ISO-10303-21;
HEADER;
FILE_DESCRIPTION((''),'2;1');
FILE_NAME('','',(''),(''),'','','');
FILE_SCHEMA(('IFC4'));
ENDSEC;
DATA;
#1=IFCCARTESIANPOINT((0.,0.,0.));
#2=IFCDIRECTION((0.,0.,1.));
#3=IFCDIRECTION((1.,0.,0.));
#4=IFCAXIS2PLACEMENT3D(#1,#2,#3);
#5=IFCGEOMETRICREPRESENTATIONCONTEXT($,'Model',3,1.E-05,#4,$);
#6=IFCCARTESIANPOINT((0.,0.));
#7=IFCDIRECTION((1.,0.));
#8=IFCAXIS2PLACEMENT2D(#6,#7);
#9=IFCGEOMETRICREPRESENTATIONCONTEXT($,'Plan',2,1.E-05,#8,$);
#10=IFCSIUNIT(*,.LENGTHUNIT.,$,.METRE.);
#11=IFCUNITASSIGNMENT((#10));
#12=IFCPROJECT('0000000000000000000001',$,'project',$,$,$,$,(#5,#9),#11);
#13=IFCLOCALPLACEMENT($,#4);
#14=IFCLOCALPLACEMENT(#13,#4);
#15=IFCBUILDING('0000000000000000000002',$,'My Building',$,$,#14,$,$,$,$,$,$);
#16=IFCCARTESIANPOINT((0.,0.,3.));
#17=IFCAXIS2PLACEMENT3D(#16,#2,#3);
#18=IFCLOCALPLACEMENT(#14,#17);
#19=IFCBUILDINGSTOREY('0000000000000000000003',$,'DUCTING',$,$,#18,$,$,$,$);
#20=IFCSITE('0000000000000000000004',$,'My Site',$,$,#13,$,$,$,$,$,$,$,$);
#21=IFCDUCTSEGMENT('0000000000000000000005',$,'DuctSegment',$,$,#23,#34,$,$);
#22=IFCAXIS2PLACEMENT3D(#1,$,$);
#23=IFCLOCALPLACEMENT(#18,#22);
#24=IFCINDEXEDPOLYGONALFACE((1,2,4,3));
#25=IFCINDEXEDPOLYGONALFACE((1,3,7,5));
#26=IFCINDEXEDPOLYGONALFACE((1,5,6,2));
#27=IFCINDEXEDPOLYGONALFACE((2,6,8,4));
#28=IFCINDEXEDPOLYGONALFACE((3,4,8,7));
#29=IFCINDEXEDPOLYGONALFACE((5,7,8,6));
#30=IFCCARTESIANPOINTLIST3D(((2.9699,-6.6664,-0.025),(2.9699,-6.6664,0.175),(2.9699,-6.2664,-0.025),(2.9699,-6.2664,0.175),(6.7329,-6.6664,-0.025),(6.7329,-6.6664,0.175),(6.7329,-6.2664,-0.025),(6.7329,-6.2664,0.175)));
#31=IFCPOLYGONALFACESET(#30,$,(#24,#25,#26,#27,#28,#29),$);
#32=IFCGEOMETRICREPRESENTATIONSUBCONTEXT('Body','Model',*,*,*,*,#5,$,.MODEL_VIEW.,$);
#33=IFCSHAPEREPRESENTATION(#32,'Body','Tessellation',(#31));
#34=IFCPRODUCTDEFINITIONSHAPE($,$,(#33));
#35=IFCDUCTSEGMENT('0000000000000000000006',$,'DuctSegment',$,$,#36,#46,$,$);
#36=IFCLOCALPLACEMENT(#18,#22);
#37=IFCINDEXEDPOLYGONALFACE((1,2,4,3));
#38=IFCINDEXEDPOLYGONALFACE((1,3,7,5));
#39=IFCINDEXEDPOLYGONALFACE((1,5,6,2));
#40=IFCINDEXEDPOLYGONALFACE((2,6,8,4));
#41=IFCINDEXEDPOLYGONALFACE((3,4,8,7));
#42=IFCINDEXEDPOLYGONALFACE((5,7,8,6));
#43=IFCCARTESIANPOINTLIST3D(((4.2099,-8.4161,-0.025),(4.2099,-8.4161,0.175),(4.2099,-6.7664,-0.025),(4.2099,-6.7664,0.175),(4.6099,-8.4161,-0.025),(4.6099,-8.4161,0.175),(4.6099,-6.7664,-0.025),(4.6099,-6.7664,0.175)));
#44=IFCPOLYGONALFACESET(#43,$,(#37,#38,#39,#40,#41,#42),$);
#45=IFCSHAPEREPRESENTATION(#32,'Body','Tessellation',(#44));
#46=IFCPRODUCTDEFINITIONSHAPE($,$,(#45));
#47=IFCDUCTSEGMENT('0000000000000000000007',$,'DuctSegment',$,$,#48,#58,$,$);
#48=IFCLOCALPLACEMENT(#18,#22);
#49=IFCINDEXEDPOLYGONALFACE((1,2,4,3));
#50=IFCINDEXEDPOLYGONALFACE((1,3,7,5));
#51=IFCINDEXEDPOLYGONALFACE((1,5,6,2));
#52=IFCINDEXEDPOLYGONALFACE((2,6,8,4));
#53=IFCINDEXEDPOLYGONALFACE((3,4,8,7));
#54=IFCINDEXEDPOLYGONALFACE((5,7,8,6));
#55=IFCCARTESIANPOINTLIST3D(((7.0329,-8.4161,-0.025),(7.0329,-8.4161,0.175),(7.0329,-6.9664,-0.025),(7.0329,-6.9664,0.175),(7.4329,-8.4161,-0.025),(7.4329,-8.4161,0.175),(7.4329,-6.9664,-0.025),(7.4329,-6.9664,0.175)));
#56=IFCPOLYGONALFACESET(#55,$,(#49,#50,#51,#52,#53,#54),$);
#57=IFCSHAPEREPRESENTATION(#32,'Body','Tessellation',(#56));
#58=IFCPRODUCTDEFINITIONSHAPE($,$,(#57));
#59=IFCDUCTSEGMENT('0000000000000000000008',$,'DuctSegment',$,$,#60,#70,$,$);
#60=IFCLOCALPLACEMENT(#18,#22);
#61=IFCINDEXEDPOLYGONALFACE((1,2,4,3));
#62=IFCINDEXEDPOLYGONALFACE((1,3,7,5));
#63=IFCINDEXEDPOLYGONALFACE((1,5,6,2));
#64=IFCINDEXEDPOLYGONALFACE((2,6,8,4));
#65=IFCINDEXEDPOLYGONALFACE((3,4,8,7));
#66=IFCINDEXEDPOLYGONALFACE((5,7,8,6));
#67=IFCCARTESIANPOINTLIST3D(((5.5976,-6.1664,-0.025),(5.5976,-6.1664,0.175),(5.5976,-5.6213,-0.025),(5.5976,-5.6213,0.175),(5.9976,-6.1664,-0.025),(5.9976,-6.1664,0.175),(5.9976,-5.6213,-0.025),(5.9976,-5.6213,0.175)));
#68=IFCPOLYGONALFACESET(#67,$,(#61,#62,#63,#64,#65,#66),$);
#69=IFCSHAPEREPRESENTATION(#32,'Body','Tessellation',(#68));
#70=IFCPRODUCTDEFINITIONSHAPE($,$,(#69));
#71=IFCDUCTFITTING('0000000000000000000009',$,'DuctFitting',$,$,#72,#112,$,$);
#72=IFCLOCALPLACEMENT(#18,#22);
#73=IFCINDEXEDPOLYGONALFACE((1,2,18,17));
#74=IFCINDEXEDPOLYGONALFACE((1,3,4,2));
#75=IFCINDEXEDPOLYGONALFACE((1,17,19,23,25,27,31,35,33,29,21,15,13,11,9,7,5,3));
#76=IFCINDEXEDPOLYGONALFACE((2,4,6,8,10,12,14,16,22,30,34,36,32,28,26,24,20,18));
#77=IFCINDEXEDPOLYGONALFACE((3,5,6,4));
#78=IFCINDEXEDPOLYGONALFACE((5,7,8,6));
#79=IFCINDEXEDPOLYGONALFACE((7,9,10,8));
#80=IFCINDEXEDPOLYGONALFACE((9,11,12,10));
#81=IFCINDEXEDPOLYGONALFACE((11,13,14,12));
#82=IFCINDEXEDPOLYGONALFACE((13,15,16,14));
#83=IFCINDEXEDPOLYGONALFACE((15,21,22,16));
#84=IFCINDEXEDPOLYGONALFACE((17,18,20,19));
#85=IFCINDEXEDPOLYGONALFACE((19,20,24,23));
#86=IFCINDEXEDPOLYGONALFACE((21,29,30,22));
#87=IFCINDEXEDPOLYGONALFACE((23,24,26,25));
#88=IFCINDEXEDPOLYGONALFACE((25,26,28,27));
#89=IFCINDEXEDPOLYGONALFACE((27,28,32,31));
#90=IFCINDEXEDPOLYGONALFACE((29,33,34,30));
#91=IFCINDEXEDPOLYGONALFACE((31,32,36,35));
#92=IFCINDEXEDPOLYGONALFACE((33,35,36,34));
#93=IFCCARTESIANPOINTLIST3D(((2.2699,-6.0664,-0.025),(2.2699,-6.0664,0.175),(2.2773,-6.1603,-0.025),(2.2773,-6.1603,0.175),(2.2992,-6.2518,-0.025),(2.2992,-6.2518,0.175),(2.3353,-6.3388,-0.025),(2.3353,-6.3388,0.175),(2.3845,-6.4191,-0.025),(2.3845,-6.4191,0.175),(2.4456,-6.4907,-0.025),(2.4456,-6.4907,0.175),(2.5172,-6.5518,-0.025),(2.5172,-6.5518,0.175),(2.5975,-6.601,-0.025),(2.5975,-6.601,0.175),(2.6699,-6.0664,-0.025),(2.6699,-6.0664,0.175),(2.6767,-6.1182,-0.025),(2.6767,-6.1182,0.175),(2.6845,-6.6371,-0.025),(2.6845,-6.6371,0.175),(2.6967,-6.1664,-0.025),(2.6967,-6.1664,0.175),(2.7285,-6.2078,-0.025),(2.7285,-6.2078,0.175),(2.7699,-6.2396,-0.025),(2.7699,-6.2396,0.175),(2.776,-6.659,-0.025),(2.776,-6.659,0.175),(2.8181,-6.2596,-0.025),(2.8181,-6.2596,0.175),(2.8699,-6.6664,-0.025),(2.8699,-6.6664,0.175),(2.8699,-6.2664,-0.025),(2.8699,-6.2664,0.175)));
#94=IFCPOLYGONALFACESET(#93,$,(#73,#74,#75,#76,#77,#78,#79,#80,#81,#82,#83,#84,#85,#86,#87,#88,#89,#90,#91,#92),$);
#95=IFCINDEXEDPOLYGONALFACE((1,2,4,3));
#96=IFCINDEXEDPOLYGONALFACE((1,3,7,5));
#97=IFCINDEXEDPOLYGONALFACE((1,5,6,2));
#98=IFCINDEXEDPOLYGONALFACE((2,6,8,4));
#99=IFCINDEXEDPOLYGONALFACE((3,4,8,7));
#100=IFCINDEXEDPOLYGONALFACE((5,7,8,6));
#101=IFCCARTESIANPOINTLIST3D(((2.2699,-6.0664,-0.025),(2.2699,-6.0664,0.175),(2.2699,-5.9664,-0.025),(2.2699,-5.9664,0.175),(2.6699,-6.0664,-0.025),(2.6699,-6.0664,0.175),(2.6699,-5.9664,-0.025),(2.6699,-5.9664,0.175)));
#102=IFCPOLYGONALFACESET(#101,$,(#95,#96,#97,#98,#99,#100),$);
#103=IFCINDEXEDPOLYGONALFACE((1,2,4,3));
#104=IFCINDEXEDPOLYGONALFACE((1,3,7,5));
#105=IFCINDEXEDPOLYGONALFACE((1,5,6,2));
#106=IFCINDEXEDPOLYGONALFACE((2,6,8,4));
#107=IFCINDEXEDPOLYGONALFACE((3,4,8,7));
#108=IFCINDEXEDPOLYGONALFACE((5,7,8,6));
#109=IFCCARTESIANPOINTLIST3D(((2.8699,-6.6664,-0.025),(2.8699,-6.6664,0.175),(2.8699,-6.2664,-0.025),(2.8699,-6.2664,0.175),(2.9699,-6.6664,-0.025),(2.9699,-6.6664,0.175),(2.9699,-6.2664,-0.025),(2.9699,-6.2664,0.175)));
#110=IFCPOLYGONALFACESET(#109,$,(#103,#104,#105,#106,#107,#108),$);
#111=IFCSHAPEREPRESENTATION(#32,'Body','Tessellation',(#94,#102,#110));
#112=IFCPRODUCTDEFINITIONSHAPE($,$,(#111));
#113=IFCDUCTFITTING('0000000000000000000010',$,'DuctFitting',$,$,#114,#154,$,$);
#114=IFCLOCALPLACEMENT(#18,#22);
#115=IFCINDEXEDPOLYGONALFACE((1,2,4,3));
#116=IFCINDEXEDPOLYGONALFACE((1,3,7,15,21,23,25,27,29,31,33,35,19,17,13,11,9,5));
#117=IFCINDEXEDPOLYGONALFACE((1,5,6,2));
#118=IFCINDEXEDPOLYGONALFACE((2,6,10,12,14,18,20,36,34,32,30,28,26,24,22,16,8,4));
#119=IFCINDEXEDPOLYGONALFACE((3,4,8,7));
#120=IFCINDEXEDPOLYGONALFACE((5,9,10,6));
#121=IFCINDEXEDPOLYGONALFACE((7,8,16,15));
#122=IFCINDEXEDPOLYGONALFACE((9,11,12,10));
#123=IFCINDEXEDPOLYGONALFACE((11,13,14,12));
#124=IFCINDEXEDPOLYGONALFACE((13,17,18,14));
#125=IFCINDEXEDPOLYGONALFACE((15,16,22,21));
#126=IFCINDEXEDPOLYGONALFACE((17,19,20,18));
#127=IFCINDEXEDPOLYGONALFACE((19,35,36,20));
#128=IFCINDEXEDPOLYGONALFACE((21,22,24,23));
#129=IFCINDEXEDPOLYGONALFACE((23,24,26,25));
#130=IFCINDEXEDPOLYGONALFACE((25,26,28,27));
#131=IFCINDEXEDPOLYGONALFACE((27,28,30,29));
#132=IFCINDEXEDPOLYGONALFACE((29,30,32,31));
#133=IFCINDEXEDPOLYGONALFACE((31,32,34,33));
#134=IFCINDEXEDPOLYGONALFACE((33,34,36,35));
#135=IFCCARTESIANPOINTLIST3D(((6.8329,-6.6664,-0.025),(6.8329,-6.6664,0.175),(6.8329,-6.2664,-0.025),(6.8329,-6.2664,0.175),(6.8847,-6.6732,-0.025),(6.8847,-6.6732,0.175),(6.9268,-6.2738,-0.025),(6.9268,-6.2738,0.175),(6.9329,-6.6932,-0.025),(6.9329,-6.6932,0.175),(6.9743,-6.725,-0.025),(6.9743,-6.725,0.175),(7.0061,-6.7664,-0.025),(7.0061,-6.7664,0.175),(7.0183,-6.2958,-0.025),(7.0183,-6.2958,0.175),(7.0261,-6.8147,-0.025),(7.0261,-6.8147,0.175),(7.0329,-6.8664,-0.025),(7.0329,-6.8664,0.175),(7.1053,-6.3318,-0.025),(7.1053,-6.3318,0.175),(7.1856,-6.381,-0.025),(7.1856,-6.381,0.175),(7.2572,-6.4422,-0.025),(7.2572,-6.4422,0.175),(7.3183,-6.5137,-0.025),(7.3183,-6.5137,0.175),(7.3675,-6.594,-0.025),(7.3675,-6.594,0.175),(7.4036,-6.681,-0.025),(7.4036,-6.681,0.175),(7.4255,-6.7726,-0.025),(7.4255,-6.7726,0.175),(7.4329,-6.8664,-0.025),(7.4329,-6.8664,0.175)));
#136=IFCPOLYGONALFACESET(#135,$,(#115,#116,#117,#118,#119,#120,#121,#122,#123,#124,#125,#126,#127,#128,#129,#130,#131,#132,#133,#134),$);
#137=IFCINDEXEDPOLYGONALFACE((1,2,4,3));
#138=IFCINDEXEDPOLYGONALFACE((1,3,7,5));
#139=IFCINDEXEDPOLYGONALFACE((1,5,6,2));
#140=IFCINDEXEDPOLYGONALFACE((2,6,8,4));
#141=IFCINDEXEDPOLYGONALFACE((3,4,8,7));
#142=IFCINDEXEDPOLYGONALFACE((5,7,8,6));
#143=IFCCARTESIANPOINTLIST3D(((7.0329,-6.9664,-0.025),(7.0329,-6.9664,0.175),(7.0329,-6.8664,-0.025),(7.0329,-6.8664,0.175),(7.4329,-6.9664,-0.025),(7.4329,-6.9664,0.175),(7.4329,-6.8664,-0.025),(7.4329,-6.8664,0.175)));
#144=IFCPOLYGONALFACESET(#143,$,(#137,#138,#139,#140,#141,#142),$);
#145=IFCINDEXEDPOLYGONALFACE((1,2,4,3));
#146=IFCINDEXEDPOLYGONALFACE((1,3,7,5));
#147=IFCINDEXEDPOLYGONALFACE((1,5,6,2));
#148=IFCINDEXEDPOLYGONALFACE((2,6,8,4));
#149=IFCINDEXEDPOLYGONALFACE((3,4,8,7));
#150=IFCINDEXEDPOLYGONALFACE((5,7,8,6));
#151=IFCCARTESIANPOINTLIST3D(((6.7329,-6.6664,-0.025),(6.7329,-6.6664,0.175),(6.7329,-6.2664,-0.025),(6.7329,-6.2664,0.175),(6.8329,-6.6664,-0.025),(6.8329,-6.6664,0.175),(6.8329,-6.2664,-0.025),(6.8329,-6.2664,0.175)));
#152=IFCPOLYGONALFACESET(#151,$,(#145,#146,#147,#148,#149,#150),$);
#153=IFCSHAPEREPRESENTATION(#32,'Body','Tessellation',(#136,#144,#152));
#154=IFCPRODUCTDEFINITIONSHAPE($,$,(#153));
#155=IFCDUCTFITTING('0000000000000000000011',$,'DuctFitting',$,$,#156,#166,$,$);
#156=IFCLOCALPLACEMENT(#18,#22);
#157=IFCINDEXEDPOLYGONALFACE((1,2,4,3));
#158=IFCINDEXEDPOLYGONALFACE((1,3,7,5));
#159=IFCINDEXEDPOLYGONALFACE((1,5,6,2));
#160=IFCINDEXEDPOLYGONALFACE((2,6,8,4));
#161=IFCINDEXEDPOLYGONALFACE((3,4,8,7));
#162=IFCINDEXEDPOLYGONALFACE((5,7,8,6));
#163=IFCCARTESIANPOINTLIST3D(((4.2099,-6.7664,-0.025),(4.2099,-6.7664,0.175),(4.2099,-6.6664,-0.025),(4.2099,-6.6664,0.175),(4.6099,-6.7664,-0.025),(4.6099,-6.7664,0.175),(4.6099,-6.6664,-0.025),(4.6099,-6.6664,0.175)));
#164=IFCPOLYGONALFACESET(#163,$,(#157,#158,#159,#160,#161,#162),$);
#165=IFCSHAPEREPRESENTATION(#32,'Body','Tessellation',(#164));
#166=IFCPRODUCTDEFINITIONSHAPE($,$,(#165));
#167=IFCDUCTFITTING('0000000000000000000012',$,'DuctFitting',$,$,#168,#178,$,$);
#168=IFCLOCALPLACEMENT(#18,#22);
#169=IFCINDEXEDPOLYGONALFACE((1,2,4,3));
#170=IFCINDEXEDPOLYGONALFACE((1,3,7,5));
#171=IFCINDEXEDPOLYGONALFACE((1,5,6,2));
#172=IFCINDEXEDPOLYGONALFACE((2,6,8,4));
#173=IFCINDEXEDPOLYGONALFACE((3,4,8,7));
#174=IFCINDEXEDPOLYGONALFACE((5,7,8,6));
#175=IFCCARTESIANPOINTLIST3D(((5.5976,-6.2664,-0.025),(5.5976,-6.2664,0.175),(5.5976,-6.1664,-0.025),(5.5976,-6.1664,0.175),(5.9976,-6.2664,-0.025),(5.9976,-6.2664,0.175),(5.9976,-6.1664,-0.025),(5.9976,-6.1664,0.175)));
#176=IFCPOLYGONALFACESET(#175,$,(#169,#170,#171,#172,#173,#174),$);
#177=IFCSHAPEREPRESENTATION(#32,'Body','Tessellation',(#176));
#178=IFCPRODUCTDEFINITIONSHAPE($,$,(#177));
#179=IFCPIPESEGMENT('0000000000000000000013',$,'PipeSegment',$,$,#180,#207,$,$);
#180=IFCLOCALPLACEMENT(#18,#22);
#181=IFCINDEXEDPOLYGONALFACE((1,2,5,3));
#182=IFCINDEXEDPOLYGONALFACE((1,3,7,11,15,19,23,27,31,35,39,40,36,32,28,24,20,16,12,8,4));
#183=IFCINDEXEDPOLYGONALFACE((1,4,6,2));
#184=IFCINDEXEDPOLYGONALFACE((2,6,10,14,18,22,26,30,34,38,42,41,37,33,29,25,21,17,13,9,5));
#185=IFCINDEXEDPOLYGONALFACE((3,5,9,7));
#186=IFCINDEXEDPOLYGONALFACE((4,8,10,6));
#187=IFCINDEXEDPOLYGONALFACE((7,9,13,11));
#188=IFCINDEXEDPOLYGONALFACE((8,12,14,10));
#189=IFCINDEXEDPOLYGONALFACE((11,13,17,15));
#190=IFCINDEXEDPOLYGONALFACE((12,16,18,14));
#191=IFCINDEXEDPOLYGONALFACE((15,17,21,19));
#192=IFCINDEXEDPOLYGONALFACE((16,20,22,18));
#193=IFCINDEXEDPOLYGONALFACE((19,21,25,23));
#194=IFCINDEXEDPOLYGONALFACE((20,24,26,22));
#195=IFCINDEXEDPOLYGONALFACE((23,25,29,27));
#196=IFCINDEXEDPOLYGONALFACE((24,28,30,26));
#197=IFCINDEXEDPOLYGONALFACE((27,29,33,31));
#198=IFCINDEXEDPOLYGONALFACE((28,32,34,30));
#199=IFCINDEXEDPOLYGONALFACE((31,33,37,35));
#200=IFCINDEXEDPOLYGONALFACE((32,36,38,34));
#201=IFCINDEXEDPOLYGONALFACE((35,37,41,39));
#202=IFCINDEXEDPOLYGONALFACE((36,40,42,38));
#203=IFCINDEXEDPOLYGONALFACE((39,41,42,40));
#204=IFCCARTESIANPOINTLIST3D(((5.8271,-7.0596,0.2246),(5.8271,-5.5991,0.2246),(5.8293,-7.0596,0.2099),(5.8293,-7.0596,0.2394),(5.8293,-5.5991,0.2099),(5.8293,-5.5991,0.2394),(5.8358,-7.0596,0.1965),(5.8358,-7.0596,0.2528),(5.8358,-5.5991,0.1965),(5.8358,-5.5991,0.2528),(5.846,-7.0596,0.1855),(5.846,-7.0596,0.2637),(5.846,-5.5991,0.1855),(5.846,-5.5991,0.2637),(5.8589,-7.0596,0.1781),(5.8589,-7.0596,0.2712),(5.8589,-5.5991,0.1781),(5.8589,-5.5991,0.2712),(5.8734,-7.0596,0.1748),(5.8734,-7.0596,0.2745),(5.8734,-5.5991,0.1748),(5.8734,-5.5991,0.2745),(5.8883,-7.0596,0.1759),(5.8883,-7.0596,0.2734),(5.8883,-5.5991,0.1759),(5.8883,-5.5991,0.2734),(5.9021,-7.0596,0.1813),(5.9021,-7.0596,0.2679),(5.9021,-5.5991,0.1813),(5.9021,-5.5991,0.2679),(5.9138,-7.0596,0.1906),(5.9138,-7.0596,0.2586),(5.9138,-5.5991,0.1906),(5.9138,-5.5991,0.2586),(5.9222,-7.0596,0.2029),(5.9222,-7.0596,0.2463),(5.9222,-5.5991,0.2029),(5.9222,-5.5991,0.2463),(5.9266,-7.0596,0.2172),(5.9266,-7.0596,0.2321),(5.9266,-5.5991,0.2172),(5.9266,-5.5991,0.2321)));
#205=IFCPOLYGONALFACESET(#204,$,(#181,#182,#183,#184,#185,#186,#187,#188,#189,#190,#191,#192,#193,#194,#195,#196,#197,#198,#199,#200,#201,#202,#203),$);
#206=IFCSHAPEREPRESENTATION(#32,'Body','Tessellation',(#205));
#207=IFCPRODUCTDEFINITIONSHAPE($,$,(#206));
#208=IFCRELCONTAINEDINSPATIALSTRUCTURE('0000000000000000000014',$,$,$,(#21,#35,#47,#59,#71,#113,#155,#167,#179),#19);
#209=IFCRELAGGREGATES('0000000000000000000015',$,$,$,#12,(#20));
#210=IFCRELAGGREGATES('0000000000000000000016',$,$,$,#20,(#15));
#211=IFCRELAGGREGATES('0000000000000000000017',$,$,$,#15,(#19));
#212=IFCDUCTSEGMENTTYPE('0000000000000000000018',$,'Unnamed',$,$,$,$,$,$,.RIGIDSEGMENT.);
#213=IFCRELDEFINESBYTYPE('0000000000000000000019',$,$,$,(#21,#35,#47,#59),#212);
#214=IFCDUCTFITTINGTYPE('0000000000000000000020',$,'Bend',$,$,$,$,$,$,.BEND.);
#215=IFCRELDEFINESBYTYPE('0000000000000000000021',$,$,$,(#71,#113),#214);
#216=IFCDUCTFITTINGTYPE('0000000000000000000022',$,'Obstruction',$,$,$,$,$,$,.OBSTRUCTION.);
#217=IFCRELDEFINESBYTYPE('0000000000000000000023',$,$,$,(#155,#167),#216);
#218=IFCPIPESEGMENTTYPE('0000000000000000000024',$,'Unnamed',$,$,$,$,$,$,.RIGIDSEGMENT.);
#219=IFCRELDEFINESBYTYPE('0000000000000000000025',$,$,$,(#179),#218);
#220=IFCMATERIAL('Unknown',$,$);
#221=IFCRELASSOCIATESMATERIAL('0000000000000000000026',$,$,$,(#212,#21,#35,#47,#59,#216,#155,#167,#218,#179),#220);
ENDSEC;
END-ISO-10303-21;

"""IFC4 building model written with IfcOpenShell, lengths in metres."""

from ifc_helpers import new_model, si_unit, frame, origin_with_axes, origin_2d_with_axis, place, context, subcontext, project, spatial, line, arc, indexed_curve, rectangle, circle, outline, extrude, source, transform, mapped, material, material_profile, profile_set, profile_usage, type_object, type_shapes, element, save


model = new_model("IFC4")

# Units and contexts
model_context = context("Model", 3, precision=1e-05, world=origin_with_axes())
plan_context = context("Plan", 2, precision=1e-05, world=origin_2d_with_axis())
body_context = subcontext(model_context, "Body", "Model", "MODEL_VIEW")
ifc_project = project(units=[si_unit("LENGTHUNIT", "METRE")], contexts=[model_context, plan_context])

# Site, building, storey
site_placement = place(None, origin_with_axes())
site = spatial("IfcSite", under=ifc_project, at=site_placement, Name="My Site")
building_placement = place(site_placement, origin_with_axes())
building = spatial("IfcBuilding", under=site, at=building_placement, Name="My Building")
storey_placement = place(building_placement, frame((0.0, 0.0, 3.0), z_axis=(0.0, 0.0, 1.0), x_axis=(1.0, 0.0, 0.0)))
storey = spatial("IfcBuildingStorey", under=building, at=storey_placement, Name="DUCTING")

# Duct segments
ifc_material = material(Name="Unknown")
ifc_material_profile_1 = material_profile(ifc_material, rectangle(XDim=0.4, YDim=0.2))
ifc_profile_set_1 = profile_set([ifc_material_profile_1])
ifc_profile_usage_1 = profile_usage(ifc_profile_set_1, cardinal=5)
duct_segment_type = type_object("IfcDuctSegmentType", Name="Unnamed", PredefinedType="RIGIDSEGMENT", material=ifc_profile_set_1)
duct_segment_1_placement = place(storey_placement, frame((2.9699, -6.4664, 0.075), z_axis=(1.0, 0.0, 0.0), x_axis=(0.0, 1.0, 0.0)))
element("IfcDuctSegment", 1, at=duct_segment_1_placement, inside=storey, type_object=duct_segment_type, material=ifc_profile_usage_1, Name="DuctSegment", context=body_context, shape_type="SweptSolid", body=[
    extrude(rectangle(XDim=0.4, YDim=0.2), origin_with_axes(), (0.0, 0.0, 1.0), 3.763),
])
ifc_profile_usage_2 = profile_usage(ifc_profile_set_1, cardinal=5)
duct_segment_2_placement = place(storey_placement, frame((4.4099, -6.7664, 0.075), z_axis=(0.0, -1.0, 0.0), x_axis=(1.0, 0.0, 0.0)))
element("IfcDuctSegment", 2, at=duct_segment_2_placement, inside=storey, type_object=duct_segment_type, material=ifc_profile_usage_2, Name="DuctSegment", context=body_context, shape_type="SweptSolid", body=[
    extrude(rectangle(XDim=0.4, YDim=0.2), origin_with_axes(), (0.0, 0.0, 1.0), 1.6497),
])
ifc_profile_usage_3 = profile_usage(ifc_profile_set_1, cardinal=5)
duct_segment_3_placement = place(storey_placement, frame((7.2329, -6.9664, 0.075), z_axis=(0.0, -1.0, 0.0), x_axis=(1.0, 0.0, 0.0)))
element("IfcDuctSegment", 3, at=duct_segment_3_placement, inside=storey, type_object=duct_segment_type, material=ifc_profile_usage_3, Name="DuctSegment", context=body_context, shape_type="SweptSolid", body=[
    extrude(rectangle(XDim=0.4, YDim=0.2), origin_with_axes(), (0.0, 0.0, 1.0), 1.4497),
])
ifc_profile_usage_4 = profile_usage(ifc_profile_set_1, cardinal=5)
duct_segment_4_placement = place(storey_placement, frame((5.7976, -6.1664, 0.075), z_axis=(0.0, 1.0, 0.0), x_axis=(-1.0, 0.0, 0.0)))
element("IfcDuctSegment", 4, at=duct_segment_4_placement, inside=storey, type_object=duct_segment_type, material=ifc_profile_usage_4, Name="DuctSegment", context=body_context, shape_type="SweptSolid", body=[
    extrude(rectangle(XDim=0.4, YDim=0.2), origin_with_axes(), (0.0, 0.0, 1.0), 0.5451),
])

# Duct fittings
duct_fitting_type_1 = type_object("IfcDuctFittingType", Name="Bend", PredefinedType="BEND")
shared_shape_1 = source(origin_with_axes(), body_context, "Body", "SweptSolid", [
    extrude(outline(indexed_curve([(0.2, 0.0), (0.2586, 0.1414), (0.4, 0.2), (0.4, 0.6), (-0.0243, 0.4243), (-0.2, 0.0)], segments=[arc(1, 2, 3), line(3, 4), arc(4, 5, 6), line(6, 1)])), frame((0.0, -0.1, 0.1), z_axis=(0.0, -1.0, 0.0), x_axis=(1.0, 0.0, 0.0)), (0.0, 0.0, -1.0), 0.2),
    extrude(rectangle(XDim=0.4, YDim=0.2), origin_with_axes(), (0.0, 0.0, 1.0), 0.1),
    extrude(rectangle(XDim=0.4, YDim=0.2), frame((0.4, 0.0, 0.5), z_axis=(1.0, 0.0, 0.0), x_axis=(0.0, 0.0, 1.0)), (0.0, 0.0, 1.0), 0.1),
])
type_shapes(duct_fitting_type_1, [shared_shape_1])
for number, where, z_axis, x_axis, name in (
    (5, (2.4699, -5.9664, 0.075), (0.0, -1.0, 0.0), (1.0, 0.0, 0.0), "DuctFitting"),
    (6, (7.2329, -6.9664, 0.075), (0.0, 1.0, 0.0), (-1.0, 0.0, 0.0), "DuctFitting"),
):
    element("IfcDuctFitting", number, at=place(storey_placement, frame(where, z_axis=z_axis, x_axis=x_axis)), inside=storey, type_object=duct_fitting_type_1, Name=name, context=body_context, shape_type="MappedRepresentation", body=[
        mapped(shared_shape_1, transform((0.0, 0.0, 0.0), x_axis=(1.0, 0.0, 0.0), y_axis=(0.0, 1.0, 0.0), z_axis=(0.0, 0.0, 1.0), scale=1.0)),
    ])
ifc_material_profile_2 = material_profile(ifc_material, rectangle(XDim=0.4, YDim=0.2))
ifc_profile_set_2 = profile_set([ifc_material_profile_2])
ifc_profile_usage_5 = profile_usage(ifc_profile_set_2, cardinal=5)
duct_fitting_type_2 = type_object("IfcDuctFittingType", Name="Obstruction", PredefinedType="OBSTRUCTION", material=ifc_profile_set_2)
duct_fitting_1_placement = place(storey_placement, frame((4.4099, -6.6664, 0.075), z_axis=(0.0, -1.0, 0.0), x_axis=(1.0, 0.0, 0.0)))
element("IfcDuctFitting", 7, at=duct_fitting_1_placement, inside=storey, type_object=duct_fitting_type_2, material=ifc_profile_usage_5, Name="DuctFitting", context=body_context, shape_type="SweptSolid", body=[
    extrude(rectangle(XDim=0.4, YDim=0.2), origin_with_axes(), (0.0, 0.0, 1.0), 0.1),
])
ifc_profile_usage_6 = profile_usage(ifc_profile_set_2, cardinal=5)
duct_fitting_2_placement = place(storey_placement, frame((5.7976, -6.2664, 0.075), z_axis=(0.0, 1.0, 0.0), x_axis=(-1.0, 0.0, 0.0)))
element("IfcDuctFitting", 8, at=duct_fitting_2_placement, inside=storey, type_object=duct_fitting_type_2, material=ifc_profile_usage_6, Name="DuctFitting", context=body_context, shape_type="SweptSolid", body=[
    extrude(rectangle(XDim=0.4, YDim=0.2), origin_with_axes(), (0.0, 0.0, 1.0), 0.1),
])

# Pipe segment
ifc_material_profile_3 = material_profile(ifc_material, circle(Radius=0.05))
ifc_profile_set_3 = profile_set([ifc_material_profile_3])
ifc_profile_usage_7 = profile_usage(ifc_profile_set_3, cardinal=5)
pipe_segment_type = type_object("IfcPipeSegmentType", Name="Unnamed", PredefinedType="RIGIDSEGMENT", material=ifc_profile_set_3)
pipe_segment_1_placement = place(storey_placement, frame((5.8771, -7.0596, 0.2246), z_axis=(0.0, 1.0, 0.0), x_axis=(-1.0, 0.0, 0.0)))
element("IfcPipeSegment", 9, at=pipe_segment_1_placement, inside=storey, type_object=pipe_segment_type, material=ifc_profile_usage_7, Name="PipeSegment", context=body_context, shape_type="SweptSolid", body=[
    extrude(circle(Radius=0.05), origin_with_axes(), (0.0, 0.0, 1.0), 1.4605),
])

save(model, "model.ifc")
